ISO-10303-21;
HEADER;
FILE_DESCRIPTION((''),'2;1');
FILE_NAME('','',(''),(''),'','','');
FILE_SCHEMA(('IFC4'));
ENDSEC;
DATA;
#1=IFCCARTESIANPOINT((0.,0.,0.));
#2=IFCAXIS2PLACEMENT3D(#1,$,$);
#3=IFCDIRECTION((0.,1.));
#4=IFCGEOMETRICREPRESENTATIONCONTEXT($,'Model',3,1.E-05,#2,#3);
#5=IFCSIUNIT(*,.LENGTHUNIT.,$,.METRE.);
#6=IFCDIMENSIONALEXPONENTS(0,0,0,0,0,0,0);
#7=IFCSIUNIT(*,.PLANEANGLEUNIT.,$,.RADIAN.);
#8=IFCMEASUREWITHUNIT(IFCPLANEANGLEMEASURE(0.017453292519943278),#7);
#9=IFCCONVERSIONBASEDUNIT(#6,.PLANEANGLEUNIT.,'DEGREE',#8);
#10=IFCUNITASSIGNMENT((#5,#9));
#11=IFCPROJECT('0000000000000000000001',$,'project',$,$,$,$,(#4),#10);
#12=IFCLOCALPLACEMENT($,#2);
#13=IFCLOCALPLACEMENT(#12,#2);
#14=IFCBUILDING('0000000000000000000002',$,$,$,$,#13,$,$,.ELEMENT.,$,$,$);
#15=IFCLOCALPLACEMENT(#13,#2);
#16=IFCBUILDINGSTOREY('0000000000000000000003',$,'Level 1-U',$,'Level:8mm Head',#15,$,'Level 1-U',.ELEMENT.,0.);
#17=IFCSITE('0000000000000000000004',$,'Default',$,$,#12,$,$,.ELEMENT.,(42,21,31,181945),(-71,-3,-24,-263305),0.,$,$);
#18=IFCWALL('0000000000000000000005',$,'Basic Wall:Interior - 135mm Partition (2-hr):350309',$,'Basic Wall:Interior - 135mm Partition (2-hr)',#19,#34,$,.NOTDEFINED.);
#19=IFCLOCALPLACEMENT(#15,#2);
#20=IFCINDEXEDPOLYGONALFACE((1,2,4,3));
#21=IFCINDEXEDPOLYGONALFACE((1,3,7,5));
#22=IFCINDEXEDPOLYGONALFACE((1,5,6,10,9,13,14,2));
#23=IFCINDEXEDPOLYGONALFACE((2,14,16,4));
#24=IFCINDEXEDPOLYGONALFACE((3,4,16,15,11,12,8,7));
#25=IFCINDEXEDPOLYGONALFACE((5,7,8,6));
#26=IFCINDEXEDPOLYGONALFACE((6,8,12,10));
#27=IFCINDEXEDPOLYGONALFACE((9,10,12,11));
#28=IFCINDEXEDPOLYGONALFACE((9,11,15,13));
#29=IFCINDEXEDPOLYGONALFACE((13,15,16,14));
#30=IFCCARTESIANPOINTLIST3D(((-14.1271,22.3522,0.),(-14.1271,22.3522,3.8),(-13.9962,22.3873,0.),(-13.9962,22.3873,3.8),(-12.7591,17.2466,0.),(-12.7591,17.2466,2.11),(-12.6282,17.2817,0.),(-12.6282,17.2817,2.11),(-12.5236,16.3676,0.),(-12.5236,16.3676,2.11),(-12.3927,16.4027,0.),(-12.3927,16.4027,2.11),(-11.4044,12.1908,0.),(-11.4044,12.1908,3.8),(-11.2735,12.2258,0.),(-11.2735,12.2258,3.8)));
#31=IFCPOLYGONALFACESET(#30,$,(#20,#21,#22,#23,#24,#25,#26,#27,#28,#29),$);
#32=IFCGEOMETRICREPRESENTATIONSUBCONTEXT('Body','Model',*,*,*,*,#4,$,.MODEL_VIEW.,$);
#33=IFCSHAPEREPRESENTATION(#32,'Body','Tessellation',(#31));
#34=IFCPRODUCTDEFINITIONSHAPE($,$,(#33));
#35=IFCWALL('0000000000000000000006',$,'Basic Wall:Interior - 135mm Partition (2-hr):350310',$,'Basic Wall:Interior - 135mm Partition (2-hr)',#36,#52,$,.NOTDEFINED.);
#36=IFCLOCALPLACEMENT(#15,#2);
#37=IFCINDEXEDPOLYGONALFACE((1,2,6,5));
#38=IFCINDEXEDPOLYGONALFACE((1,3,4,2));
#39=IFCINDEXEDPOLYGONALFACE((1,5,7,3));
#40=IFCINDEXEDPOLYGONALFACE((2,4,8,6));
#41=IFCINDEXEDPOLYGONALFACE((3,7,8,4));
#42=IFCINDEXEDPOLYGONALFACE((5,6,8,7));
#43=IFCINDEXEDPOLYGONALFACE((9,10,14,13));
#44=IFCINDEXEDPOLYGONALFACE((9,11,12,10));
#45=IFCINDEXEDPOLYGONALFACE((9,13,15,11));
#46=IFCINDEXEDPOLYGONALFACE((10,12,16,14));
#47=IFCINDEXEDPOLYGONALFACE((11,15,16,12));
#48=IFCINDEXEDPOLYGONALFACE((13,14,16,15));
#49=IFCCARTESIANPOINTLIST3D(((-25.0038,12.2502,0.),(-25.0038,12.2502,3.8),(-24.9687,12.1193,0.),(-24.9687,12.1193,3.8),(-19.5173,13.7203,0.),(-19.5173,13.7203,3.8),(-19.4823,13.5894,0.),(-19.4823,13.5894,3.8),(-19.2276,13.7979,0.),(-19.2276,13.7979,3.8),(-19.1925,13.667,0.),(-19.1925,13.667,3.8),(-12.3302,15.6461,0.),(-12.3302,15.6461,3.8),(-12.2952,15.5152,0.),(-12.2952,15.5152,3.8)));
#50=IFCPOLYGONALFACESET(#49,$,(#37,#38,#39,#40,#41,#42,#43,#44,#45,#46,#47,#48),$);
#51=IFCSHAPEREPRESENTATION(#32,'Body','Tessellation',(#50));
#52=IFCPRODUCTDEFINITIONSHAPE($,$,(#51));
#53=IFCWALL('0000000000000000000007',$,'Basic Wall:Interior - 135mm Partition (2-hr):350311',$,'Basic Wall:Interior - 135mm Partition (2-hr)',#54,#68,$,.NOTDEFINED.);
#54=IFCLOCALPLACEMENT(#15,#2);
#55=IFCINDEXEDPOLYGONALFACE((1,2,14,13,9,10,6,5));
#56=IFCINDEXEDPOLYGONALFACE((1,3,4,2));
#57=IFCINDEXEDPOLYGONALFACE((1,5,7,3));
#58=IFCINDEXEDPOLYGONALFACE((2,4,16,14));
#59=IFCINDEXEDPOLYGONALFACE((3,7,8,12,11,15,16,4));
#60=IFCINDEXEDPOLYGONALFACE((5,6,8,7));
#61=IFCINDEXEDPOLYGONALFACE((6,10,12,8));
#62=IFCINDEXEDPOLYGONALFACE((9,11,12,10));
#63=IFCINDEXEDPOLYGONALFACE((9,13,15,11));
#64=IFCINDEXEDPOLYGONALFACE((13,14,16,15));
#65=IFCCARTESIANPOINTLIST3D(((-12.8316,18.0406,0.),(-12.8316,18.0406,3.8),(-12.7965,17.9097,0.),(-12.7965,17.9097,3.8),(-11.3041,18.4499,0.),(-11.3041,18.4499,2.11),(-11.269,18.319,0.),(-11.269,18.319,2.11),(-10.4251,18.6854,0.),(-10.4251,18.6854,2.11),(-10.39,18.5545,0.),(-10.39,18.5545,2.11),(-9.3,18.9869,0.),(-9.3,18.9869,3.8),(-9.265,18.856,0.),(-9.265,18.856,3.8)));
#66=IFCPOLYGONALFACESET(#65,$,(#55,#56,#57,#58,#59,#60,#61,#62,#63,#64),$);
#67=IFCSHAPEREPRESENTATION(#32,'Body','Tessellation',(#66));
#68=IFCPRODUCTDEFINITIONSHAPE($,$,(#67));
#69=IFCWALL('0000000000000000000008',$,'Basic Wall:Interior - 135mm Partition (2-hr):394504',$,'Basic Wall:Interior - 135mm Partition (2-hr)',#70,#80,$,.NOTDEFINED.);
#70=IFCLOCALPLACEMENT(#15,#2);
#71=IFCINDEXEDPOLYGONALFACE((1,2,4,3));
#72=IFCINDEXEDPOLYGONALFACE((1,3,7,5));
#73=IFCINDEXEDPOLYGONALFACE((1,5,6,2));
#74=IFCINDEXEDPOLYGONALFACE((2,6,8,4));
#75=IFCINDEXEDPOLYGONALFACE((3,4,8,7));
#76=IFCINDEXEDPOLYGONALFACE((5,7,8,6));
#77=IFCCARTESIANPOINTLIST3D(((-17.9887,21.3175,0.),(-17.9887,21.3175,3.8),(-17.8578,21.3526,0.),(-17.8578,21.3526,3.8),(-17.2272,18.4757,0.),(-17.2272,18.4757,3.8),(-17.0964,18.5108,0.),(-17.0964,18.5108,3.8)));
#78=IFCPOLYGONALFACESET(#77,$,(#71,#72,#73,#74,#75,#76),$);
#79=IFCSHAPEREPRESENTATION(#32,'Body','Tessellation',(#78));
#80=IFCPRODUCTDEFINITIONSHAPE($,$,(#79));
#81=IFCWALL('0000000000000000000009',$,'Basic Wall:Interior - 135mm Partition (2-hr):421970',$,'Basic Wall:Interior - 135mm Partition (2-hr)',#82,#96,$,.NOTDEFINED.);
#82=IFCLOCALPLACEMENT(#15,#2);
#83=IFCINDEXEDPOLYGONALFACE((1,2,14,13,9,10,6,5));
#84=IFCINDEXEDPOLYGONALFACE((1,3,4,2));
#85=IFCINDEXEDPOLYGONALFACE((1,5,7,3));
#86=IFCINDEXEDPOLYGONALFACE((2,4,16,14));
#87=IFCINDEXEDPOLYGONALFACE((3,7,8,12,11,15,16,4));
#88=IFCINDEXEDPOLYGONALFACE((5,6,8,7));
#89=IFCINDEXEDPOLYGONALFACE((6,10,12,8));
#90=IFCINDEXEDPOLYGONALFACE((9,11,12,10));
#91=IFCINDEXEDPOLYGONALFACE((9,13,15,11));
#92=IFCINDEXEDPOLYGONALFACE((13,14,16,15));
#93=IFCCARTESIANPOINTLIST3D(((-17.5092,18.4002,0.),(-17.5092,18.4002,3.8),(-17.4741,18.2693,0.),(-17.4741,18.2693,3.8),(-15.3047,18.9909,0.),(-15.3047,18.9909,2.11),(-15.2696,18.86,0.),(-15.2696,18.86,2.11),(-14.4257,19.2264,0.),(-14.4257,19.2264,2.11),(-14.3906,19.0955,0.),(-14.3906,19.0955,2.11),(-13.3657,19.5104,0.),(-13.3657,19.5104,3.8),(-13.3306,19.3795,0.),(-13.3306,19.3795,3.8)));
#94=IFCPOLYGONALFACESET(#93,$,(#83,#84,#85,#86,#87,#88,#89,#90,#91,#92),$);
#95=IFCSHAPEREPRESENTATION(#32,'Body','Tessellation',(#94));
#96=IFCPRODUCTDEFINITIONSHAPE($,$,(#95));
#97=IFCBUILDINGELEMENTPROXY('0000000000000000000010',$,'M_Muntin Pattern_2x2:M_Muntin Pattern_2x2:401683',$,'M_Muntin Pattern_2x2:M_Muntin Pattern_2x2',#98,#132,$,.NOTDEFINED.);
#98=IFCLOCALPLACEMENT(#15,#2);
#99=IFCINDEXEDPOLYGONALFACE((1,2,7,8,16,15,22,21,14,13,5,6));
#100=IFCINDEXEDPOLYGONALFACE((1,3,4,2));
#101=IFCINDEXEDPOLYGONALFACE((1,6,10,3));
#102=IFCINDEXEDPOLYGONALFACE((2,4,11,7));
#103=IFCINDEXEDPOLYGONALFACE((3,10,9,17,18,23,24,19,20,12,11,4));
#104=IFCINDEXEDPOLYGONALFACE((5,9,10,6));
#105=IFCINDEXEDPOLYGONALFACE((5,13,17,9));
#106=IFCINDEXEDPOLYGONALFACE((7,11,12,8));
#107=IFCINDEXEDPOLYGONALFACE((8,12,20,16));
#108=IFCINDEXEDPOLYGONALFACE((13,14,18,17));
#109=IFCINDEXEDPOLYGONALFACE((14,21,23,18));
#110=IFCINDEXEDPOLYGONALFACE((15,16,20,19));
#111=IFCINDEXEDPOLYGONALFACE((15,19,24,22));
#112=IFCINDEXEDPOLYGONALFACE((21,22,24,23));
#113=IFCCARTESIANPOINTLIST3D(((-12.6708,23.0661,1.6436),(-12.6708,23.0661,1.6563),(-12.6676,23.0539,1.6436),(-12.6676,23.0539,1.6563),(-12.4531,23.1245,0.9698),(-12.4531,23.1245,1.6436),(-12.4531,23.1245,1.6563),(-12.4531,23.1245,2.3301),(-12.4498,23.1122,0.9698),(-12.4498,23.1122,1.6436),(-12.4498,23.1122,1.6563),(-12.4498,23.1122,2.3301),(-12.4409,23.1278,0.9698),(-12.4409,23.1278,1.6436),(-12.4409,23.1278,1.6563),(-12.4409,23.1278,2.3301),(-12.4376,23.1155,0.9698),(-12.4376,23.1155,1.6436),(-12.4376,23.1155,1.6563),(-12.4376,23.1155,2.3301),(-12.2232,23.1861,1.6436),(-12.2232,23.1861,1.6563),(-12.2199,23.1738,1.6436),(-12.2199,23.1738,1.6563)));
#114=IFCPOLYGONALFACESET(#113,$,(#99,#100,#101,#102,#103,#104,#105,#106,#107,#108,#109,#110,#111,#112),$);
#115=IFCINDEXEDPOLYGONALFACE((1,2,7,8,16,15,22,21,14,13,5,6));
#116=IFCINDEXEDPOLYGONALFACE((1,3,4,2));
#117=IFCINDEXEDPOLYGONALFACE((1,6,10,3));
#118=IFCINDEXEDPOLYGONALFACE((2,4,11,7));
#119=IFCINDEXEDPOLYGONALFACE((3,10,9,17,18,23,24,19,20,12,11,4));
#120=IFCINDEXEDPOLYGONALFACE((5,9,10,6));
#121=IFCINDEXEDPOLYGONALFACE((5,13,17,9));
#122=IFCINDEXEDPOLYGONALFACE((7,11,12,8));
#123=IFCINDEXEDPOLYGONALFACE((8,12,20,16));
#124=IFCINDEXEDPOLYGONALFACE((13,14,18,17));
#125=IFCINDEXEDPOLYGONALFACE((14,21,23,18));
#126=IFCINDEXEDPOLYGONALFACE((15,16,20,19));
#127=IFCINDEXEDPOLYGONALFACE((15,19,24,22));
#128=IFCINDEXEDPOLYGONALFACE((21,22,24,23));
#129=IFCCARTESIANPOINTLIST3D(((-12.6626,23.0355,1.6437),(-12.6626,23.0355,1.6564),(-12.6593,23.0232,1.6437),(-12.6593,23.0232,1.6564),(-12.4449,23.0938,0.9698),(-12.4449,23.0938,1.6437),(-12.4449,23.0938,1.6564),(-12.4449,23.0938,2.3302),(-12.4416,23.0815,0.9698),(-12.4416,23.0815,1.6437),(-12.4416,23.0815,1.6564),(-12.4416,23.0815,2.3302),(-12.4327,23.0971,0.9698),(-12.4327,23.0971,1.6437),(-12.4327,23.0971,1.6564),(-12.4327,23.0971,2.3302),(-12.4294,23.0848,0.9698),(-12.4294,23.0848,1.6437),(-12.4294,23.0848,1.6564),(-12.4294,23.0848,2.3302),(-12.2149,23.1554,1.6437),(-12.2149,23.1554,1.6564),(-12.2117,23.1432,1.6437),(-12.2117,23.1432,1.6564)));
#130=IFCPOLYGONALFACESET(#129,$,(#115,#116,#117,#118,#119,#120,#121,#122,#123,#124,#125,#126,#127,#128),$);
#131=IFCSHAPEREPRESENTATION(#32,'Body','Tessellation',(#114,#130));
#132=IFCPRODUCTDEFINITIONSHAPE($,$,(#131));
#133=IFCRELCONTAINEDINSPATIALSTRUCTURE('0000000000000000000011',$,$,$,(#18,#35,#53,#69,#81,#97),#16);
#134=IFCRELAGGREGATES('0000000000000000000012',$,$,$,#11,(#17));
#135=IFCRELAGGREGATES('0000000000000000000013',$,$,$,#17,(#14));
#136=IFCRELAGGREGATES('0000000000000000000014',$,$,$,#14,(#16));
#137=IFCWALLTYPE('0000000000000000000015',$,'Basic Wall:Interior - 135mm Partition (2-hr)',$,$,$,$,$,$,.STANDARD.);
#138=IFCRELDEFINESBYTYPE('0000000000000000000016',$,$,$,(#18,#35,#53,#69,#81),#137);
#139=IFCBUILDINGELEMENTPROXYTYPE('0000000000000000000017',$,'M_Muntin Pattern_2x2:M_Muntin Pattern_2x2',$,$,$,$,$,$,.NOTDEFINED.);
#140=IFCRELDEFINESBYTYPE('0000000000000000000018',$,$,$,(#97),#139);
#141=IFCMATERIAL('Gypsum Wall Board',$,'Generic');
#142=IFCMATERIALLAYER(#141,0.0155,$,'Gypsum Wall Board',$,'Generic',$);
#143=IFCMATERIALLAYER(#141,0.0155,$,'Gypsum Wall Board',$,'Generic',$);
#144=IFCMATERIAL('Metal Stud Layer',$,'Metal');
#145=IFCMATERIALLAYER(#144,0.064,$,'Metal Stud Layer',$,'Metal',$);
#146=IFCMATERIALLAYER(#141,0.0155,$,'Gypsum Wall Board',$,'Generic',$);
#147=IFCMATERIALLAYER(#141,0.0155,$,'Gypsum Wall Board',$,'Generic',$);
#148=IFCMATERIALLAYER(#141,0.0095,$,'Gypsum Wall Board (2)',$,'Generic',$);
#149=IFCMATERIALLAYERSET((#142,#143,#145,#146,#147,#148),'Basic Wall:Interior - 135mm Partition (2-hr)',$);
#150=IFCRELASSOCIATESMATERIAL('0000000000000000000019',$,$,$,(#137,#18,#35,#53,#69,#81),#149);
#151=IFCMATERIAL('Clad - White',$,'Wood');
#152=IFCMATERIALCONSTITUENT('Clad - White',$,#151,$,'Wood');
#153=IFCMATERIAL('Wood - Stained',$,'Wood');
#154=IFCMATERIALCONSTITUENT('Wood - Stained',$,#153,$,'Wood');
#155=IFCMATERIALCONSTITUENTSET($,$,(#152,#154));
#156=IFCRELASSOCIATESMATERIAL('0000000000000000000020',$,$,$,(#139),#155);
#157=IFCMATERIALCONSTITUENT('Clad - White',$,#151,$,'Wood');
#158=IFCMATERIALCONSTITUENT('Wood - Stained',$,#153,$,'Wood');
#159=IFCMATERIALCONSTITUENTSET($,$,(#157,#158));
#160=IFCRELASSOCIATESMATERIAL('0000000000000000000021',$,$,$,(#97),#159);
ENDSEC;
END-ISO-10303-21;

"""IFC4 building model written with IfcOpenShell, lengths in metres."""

from ifc_helpers import new_model, entity, si_unit, converted_unit, direction, frame, frame_2d, origin, place, context, subcontext, project, spatial, polyline, rectangle, outline, extrude, source, transform, mapped, material, layer, layer_set, layer_usage, constituent, constituent_set, type_object, type_shapes, element, save


model = new_model("IFC4")

# Units and contexts
model_context = context("Model", 3, precision=1e-05, world=origin(), true_north=direction((0.0, 1.0)))
body_context = subcontext(model_context, "Body", "Model", "MODEL_VIEW")
ifc_project = project(units=[si_unit("LENGTHUNIT", "METRE"), converted_unit("PLANEANGLEUNIT", "DEGREE", entity("IfcPlaneAngleMeasure", 0.017453292519943278), si_unit("PLANEANGLEUNIT", "RADIAN"), dimensions=[0, 0, 0, 0, 0, 0, 0])], contexts=[model_context])

# Site, building, storey
site_placement = place(None, origin())
site = spatial("IfcSite", under=ifc_project, at=site_placement, Name="Default", CompositionType="ELEMENT", RefLatitude=(42, 21, 31, 181945), RefLongitude=(-71, -3, -24, -263305), RefElevation=0.0)
building_placement = place(site_placement, origin())
building = spatial("IfcBuilding", under=site, at=building_placement, CompositionType="ELEMENT")
storey_placement = place(building_placement, origin())
storey = spatial("IfcBuildingStorey", under=building, at=storey_placement, Name="Level 1-U", ObjectType="Level:8mm Head", LongName="Level 1-U", CompositionType="ELEMENT", Elevation=0.0)

# Walls, openings
ifc_material_1 = material(Name="Gypsum Wall Board", Category="Generic")
ifc_layer_1 = layer(ifc_material_1, 0.0155, Name="Gypsum Wall Board", Category="Generic")
ifc_layer_2 = layer(ifc_material_1, 0.0155, Name="Gypsum Wall Board", Category="Generic")
ifc_material_2 = material(Name="Metal Stud Layer", Category="Metal")
ifc_layer_3 = layer(ifc_material_2, 0.064, Name="Metal Stud Layer", Category="Metal")
ifc_layer_4 = layer(ifc_material_1, 0.0155, Name="Gypsum Wall Board", Category="Generic")
ifc_layer_5 = layer(ifc_material_1, 0.0155, Name="Gypsum Wall Board", Category="Generic")
ifc_layer_6 = layer(ifc_material_1, 0.0095, Name="Gypsum Wall Board (2)", Category="Generic")
ifc_layer_set = layer_set([ifc_layer_1, ifc_layer_2, ifc_layer_3, ifc_layer_4, ifc_layer_5, ifc_layer_6], Name="Basic Wall:Interior - 135mm Partition (2-hr)")
ifc_layer_usage = layer_usage(ifc_layer_set, "AXIS2", "NEGATIVE", 0.0677)
wall_type = type_object("IfcWallType", Name="Basic Wall:Interior - 135mm Partition (2-hr)", PredefinedType="STANDARD", material=ifc_layer_set)
wall_1_placement = place(storey_placement, frame((-14.0617, 22.3697, 0.0), z_axis=(0.0, 0.0, 1.0), x_axis=(0.258819, -0.965926, 0.0)))
wall_1 = element("IfcWall", 1, at=wall_1_placement, inside=storey, type_object=wall_type, material=ifc_layer_usage, Name="Basic Wall:Interior - 135mm Partition (2-hr):350309", ObjectType="Basic Wall:Interior - 135mm Partition (2-hr)", PredefinedType="NOTDEFINED", context=body_context, shape_type="SweptSolid", body=[
    extrude(rectangle(XDim=10.5199, YDim=0.1355, at=frame_2d((5.2599, 0.0), x_axis=(1.0, 0.0))), origin(), (0.0, 0.0, 1.0), 3.8),
])
opening_1_placement = place(wall_1_placement, frame((6.1957, 0.0677, 0.0)))
element("IfcOpeningElement", 2, at=opening_1_placement, cuts=wall_1, PredefinedType="OPENING", context=body_context, shape_type="SweptSolid", body=[
    extrude(rectangle(XDim=2.11, YDim=0.91, at=frame_2d((1.055, 0.455), x_axis=(1.0, 0.0))), frame((0.0, 0.0, 0.0), z_axis=(0.0, -1.0, 0.0), x_axis=(0.0, 0.0, 1.0)), (0.0, 0.0, 1.0), 0.1355),
])
wall_2_placement = place(storey_placement, frame((-12.3127, 15.5806, 0.0), z_axis=(0.0, 0.0, 1.0), x_axis=(-0.965926, -0.258819, 0.0)))
wall_2 = element("IfcWall", 3, at=wall_2_placement, inside=storey, type_object=wall_type, material=ifc_layer_usage, Name="Basic Wall:Interior - 135mm Partition (2-hr):350310", ObjectType="Basic Wall:Interior - 135mm Partition (2-hr)", PredefinedType="NOTDEFINED", context=body_context, shape_type="SweptSolid", body=[
    extrude(rectangle(XDim=13.1207, YDim=0.1355, at=frame_2d((6.5603, 0.0), x_axis=(-1.0, 0.0))), origin(), (0.0, 0.0, 1.0), 3.8),
])
opening_2_placement = place(storey_placement, frame((-12.3127, 15.5806, 0.0), z_axis=(0.0, 0.0, 1.0), x_axis=(-0.965926, -0.258819, 0.0)))
element("IfcOpeningElement", 4, at=opening_2_placement, cuts=wall_2, PredefinedType="OPENING", context=body_context, shape_type="SweptSolid", body=[
    extrude(rectangle(XDim=3.8, YDim=0.1355, at=frame_2d((0.0, 0.0), x_axis=(1.0, 0.0))), frame((7.4407, 0.0, 1.9), z_axis=(-1.0, 0.0, 0.0), x_axis=(0.0, 0.0, 1.0)), (0.0, 0.0, 1.0), 0.3),
])
wall_3_placement = place(storey_placement, frame((-9.2825, 18.9214, 0.0), z_axis=(0.0, 0.0, 1.0), x_axis=(-0.965926, -0.258819, 0.0)))
wall_3 = element("IfcWall", 5, at=wall_3_placement, inside=storey, type_object=wall_type, material=ifc_layer_usage, Name="Basic Wall:Interior - 135mm Partition (2-hr):350311", ObjectType="Basic Wall:Interior - 135mm Partition (2-hr)", PredefinedType="NOTDEFINED", context=body_context, shape_type="SweptSolid", body=[
    extrude(rectangle(XDim=3.6561, YDim=0.1355, at=frame_2d((1.828, 0.0), x_axis=(1.0, 0.0))), origin(), (0.0, 0.0, 1.0), 3.8),
])
opening_3_placement = place(wall_3_placement, frame((2.0747, 0.0677, 0.0)))
element("IfcOpeningElement", 6, at=opening_3_placement, cuts=wall_3, PredefinedType="OPENING", context=body_context, shape_type="SweptSolid", body=[
    extrude(rectangle(XDim=2.11, YDim=0.91, at=frame_2d((1.055, 0.455), x_axis=(1.0, 0.0))), frame((0.0, 0.0, 0.0), z_axis=(0.0, -1.0, 0.0), x_axis=(0.0, 0.0, 1.0)), (0.0, 0.0, 1.0), 0.1355),
])

# Wall
wall_4_placement = place(storey_placement, frame((-17.9232, 21.335, 0.0), z_axis=(0.0, 0.0, 1.0), x_axis=(0.258819, -0.965926, 0.0)))
element("IfcWall", 7, at=wall_4_placement, inside=storey, type_object=wall_type, material=ifc_layer_usage, Name="Basic Wall:Interior - 135mm Partition (2-hr):394504", ObjectType="Basic Wall:Interior - 135mm Partition (2-hr)", PredefinedType="NOTDEFINED", context=body_context, shape_type="SweptSolid", body=[
    extrude(rectangle(XDim=2.942, YDim=0.1355, at=frame_2d((1.471, 0.0), x_axis=(-1.0, 0.0))), origin(), (0.0, 0.0, 1.0), 3.8),
])

# Wall, opening
wall_5_placement = place(storey_placement, frame((-17.4916, 18.3347, 0.0), z_axis=(0.0, 0.0, 1.0), x_axis=(0.965926, 0.258819, 0.0)))
wall_5 = element("IfcWall", 8, at=wall_5_placement, inside=storey, type_object=wall_type, material=ifc_layer_usage, Name="Basic Wall:Interior - 135mm Partition (2-hr):421970", ObjectType="Basic Wall:Interior - 135mm Partition (2-hr)", PredefinedType="NOTDEFINED", context=body_context, shape_type="SweptSolid", body=[
    extrude(rectangle(XDim=4.2897, YDim=0.1355, at=frame_2d((2.1448, 0.0), x_axis=(1.0, 0.0))), origin(), (0.0, 0.0, 1.0), 3.8),
])
opening_4_placement = place(wall_5_placement, frame((3.1923, 0.0677, 0.0)))
element("IfcOpeningElement", 9, at=opening_4_placement, cuts=wall_5, PredefinedType="OPENING", context=body_context, shape_type="SweptSolid", body=[
    extrude(rectangle(XDim=2.11, YDim=0.91, at=frame_2d((1.055, 0.455), x_axis=(1.0, 0.0))), frame((0.0, 0.0, 0.0), z_axis=(0.0, -1.0, 0.0), x_axis=(0.0, 0.0, 1.0)), (0.0, 0.0, 1.0), 0.1355),
])

# Building element proxy
ifc_material_3 = material(Name="Clad - White", Category="Wood")
ifc_constituent_1 = constituent(ifc_material_3, Name="Clad - White", Category="Wood")
ifc_material_4 = material(Name="Wood - Stained", Category="Wood")
ifc_constituent_2 = constituent(ifc_material_4, Name="Wood - Stained", Category="Wood")
ifc_constituent_set_1 = constituent_set(constituents=[ifc_constituent_1, ifc_constituent_2])
ifc_constituent_3 = constituent(ifc_material_3, Name="Clad - White", Category="Wood")
ifc_constituent_4 = constituent(ifc_material_4, Name="Wood - Stained", Category="Wood")
ifc_constituent_set_2 = constituent_set(constituents=[ifc_constituent_3, ifc_constituent_4])
building_element_proxy_type_1 = type_object("IfcBuildingElementProxyType", Name="M_Muntin Pattern_2x2:M_Muntin Pattern_2x2", PredefinedType="NOTDEFINED", material=ifc_constituent_set_2)
shared_shape_1 = source(origin(), body_context, "Body", "SweptSolid", [
    extrude(outline(polyline([(0.0064, -0.0064), (0.6801, -0.0064), (0.6801, 0.0063), (0.0064, 0.0063), (0.0064, 0.2317), (-0.0063, 0.2317), (-0.0063, 0.0063), (-0.6802, 0.0063), (-0.6802, -0.0064), (-0.0063, -0.0064), (-0.0063, -0.2317), (0.0064, -0.2317), (0.0064, -0.0064)])), frame((0.0, 0.0095, 0.6801), z_axis=(0.0, 1.0, 0.0), x_axis=(0.0, 0.0, 1.0)), (0.0, 0.0, 1.0), 0.0127),
    extrude(outline(polyline([(0.0064, -0.0064), (0.6802, -0.0064), (0.6802, 0.0063), (0.0064, 0.0063), (0.0064, 0.2317), (-0.0063, 0.2317), (-0.0063, 0.0063), (-0.6802, 0.0063), (-0.6802, -0.0064), (-0.0063, -0.0064), (-0.0063, -0.2317), (0.0064, -0.2317), (0.0064, -0.0064)])), frame((0.0, -0.0222, 0.6802), z_axis=(0.0, 1.0, 0.0), x_axis=(0.0, 0.0, 1.0)), (0.0, 0.0, 1.0), 0.0127),
])
type_shapes(building_element_proxy_type_1, [shared_shape_1])
proxy_1_placement = place(storey_placement, frame((-12.4412, 23.1047, 0.9698), z_axis=(0.0, 0.0, 1.0), x_axis=(0.965926, 0.258819, 0.0)))
element("IfcBuildingElementProxy", 10, at=proxy_1_placement, inside=storey, type_object=building_element_proxy_type_1, material=ifc_constituent_set_1, Name="M_Muntin Pattern_2x2:M_Muntin Pattern_2x2:401683", ObjectType="M_Muntin Pattern_2x2:M_Muntin Pattern_2x2", PredefinedType="NOTDEFINED", context=body_context, shape_type="MappedRepresentation", body=[
    mapped(shared_shape_1, transform((0.0, 0.0, 0.0), scale=1.0)),
])

save(model, "model.ifc")
